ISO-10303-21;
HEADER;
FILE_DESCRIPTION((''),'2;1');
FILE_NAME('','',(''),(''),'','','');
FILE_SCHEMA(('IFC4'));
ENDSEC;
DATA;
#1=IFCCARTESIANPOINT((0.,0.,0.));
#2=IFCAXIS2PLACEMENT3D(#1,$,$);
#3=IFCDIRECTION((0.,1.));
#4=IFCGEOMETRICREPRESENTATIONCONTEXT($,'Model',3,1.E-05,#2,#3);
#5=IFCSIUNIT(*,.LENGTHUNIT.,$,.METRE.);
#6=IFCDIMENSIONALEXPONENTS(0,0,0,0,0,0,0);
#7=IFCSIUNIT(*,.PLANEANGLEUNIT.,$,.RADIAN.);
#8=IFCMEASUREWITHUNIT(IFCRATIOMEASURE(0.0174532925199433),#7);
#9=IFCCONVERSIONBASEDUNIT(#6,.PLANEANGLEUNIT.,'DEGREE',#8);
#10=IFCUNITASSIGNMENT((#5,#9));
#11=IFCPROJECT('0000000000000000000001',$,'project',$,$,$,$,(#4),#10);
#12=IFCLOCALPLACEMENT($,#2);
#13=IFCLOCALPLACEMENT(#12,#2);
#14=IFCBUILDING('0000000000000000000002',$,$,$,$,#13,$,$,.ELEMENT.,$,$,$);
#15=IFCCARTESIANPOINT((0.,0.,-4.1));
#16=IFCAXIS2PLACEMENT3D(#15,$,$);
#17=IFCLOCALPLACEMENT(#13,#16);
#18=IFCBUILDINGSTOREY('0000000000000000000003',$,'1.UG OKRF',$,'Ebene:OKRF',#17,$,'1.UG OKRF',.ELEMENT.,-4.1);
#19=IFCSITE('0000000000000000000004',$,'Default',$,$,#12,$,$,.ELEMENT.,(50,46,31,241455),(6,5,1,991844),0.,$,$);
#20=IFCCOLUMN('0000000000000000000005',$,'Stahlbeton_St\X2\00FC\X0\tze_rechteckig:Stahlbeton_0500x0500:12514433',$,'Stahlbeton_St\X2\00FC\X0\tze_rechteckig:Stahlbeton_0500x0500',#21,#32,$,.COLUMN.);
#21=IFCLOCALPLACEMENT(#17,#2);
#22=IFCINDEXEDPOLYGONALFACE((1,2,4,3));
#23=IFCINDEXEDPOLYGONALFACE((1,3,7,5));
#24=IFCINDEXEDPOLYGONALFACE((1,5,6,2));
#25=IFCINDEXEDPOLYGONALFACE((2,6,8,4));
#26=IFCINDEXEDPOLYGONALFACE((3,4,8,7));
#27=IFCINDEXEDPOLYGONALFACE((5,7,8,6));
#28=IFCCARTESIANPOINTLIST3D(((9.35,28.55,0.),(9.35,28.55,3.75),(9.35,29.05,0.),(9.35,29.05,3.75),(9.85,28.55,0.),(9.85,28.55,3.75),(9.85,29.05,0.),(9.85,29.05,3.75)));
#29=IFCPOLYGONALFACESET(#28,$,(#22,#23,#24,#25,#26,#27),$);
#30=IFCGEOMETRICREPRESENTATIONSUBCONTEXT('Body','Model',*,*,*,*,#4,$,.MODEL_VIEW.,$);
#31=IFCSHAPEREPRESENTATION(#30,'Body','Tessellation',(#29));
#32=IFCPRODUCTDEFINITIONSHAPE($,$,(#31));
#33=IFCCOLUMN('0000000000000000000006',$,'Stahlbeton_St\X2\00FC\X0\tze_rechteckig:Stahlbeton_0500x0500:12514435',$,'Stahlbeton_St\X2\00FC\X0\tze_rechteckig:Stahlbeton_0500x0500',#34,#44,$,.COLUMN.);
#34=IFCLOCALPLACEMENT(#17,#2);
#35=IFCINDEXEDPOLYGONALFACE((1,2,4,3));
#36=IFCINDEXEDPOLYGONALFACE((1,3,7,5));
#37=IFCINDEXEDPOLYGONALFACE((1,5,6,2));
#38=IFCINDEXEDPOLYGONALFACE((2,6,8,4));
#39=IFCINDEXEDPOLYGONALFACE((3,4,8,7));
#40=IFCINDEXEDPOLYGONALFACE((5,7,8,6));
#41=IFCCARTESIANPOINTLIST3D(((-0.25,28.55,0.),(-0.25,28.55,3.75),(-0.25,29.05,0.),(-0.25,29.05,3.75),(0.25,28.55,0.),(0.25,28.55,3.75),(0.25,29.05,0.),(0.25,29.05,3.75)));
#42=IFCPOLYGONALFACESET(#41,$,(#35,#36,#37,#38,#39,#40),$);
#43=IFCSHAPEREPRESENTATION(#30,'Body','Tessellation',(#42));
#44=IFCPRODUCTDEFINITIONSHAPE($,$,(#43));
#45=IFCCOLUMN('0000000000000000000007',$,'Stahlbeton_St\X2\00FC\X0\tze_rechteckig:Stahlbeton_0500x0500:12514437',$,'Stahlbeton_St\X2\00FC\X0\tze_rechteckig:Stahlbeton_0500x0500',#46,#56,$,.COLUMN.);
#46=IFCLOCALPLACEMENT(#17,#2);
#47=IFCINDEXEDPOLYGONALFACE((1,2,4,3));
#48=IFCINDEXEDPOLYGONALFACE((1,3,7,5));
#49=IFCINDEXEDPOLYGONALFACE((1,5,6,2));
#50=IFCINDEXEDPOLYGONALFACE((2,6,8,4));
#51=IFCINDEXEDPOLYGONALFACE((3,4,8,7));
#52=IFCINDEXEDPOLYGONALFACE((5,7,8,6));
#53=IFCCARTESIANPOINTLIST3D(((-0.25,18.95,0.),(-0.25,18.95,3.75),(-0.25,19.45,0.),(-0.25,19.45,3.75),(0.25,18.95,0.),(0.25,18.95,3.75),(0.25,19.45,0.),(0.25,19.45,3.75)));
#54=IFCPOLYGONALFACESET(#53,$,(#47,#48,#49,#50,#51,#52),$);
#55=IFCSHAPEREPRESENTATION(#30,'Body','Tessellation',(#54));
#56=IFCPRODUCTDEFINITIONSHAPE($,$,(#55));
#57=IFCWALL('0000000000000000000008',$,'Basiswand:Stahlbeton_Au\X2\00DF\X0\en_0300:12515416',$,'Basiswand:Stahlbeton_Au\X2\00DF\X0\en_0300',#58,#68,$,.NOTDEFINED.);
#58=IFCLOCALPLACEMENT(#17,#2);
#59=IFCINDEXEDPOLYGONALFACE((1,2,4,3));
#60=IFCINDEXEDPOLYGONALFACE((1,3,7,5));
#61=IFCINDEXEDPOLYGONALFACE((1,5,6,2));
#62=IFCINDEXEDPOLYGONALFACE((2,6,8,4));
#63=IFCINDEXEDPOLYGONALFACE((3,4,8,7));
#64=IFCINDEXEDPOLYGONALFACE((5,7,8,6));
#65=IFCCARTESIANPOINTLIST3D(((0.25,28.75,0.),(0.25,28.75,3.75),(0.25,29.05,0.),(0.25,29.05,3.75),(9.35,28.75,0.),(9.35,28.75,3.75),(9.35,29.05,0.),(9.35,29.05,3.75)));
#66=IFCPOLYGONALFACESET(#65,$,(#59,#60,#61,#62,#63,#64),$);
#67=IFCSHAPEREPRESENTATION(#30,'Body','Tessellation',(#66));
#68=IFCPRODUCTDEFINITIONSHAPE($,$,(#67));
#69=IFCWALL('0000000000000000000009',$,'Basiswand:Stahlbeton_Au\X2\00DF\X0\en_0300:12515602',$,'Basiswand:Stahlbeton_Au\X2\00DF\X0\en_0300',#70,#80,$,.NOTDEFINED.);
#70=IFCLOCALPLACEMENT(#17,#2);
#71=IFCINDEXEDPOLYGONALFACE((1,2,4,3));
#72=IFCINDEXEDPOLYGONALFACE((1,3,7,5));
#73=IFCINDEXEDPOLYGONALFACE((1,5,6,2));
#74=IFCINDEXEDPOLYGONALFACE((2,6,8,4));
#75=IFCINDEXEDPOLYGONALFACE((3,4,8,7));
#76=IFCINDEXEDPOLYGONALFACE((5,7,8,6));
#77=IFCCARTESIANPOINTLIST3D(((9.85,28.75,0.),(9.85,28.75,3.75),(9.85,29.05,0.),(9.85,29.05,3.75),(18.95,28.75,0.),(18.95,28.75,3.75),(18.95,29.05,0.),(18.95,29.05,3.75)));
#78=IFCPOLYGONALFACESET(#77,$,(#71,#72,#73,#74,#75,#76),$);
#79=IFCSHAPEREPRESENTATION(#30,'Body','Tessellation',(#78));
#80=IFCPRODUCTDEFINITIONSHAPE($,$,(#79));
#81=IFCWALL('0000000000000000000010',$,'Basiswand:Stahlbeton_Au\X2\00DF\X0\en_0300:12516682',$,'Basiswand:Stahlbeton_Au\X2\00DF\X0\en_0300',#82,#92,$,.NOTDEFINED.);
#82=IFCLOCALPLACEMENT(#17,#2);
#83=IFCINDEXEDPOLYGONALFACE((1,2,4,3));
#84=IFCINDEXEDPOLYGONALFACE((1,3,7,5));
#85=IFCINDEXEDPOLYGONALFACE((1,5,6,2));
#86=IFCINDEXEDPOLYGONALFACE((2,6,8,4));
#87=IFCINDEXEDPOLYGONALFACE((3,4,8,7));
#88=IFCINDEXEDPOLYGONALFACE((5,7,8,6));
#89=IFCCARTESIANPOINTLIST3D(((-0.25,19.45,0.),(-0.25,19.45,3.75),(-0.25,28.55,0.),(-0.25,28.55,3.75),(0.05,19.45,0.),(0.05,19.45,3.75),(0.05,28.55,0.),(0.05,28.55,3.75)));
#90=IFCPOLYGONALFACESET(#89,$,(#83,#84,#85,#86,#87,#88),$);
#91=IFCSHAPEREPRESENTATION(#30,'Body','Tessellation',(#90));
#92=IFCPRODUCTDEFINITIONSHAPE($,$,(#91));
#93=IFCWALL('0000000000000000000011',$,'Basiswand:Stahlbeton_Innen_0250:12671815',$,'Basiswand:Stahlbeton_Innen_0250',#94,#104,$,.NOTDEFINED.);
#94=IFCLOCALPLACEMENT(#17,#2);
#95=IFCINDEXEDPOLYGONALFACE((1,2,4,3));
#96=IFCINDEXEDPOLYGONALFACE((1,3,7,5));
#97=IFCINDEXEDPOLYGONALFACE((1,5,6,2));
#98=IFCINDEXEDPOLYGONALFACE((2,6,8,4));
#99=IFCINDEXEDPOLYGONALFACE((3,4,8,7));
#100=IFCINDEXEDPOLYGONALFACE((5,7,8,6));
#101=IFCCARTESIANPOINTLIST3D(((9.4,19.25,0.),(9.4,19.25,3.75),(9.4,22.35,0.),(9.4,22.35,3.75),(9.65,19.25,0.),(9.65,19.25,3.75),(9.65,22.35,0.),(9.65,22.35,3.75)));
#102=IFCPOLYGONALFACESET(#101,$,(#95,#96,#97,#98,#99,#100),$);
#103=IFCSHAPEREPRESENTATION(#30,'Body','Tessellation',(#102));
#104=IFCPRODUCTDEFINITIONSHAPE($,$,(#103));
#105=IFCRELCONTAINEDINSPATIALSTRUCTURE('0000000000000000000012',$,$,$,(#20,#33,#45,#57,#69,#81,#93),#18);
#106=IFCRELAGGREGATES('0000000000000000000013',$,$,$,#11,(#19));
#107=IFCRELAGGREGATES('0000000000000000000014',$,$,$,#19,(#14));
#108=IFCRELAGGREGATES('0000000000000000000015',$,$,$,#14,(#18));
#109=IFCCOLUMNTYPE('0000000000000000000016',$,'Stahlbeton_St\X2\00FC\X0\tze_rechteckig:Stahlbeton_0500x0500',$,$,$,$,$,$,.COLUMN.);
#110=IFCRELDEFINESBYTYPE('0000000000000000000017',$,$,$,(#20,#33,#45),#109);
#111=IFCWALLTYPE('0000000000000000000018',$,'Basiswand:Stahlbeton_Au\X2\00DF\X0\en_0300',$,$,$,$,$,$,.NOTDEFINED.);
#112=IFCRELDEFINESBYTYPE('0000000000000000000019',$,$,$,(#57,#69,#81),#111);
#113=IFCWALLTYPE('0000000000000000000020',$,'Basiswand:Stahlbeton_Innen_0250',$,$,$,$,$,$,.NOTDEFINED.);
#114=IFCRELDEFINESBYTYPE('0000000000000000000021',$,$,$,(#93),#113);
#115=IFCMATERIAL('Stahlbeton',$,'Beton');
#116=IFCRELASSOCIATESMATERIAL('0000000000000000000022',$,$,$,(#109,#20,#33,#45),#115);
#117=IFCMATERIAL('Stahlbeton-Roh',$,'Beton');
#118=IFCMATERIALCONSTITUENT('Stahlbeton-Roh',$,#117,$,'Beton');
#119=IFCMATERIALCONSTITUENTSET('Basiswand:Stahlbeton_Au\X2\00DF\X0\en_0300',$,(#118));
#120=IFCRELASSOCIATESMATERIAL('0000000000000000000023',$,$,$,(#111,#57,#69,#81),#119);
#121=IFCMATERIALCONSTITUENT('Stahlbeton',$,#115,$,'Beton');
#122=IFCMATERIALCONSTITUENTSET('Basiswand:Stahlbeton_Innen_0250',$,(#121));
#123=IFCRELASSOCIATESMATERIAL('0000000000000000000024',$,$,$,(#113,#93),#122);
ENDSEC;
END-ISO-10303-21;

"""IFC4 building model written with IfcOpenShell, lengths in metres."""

from ifc_helpers import new_model, entity, si_unit, converted_unit, direction, frame, origin, place, context, subcontext, project, spatial, polyline, indexed_curve, outline, extrude, source, transform, mapped, material, constituent, constituent_set, type_object, type_shapes, element, save


model = new_model("IFC4")

# Units and contexts
model_context = context("Model", 3, precision=1e-05, world=origin(), true_north=direction((0.0, 1.0)))
body_context = subcontext(model_context, "Body", "Model", "MODEL_VIEW")
ifc_project = project(units=[si_unit("LENGTHUNIT", "METRE"), converted_unit("PLANEANGLEUNIT", "DEGREE", entity("IfcRatioMeasure", 0.0174532925199433), si_unit("PLANEANGLEUNIT", "RADIAN"), dimensions=[0, 0, 0, 0, 0, 0, 0])], contexts=[model_context])

# Site, building, storey
site_placement = place(None, origin())
site = spatial("IfcSite", under=ifc_project, at=site_placement, Name="Default", CompositionType="ELEMENT", RefLatitude=(50, 46, 31, 241455), RefLongitude=(6, 5, 1, 991844), RefElevation=0.0)
building_placement = place(site_placement, origin())
building = spatial("IfcBuilding", under=site, at=building_placement, CompositionType="ELEMENT")
storey_placement = place(building_placement, frame((0.0, 0.0, -4.1)))
storey = spatial("IfcBuildingStorey", under=building, at=storey_placement, Name="1.UG OKRF", ObjectType="Ebene:OKRF", LongName="1.UG OKRF", CompositionType="ELEMENT", Elevation=-4.1)

# Columns
ifc_material_1 = material(Name="Stahlbeton", Category="Beton")
column_type = type_object("IfcColumnType", Name="Stahlbeton_Stütze_rechteckig:Stahlbeton_0500x0500", PredefinedType="COLUMN", material=ifc_material_1)
shared_shape = source(origin(), body_context, "Body", "SweptSolid", [
    extrude(outline(indexed_curve([(-0.25, -0.25), (0.25, -0.25), (0.25, 0.25), (-0.25, 0.25), (-0.25, -0.25)], self_intersect=False)), frame((0.0, 0.0, -4.1), z_axis=(0.0, 0.0, 1.0), x_axis=(0.0, -1.0, 0.0)), (0.0, 0.0, 1.0), 3.75),
])
type_shapes(column_type, [shared_shape])
for number, where, name in (
    (1, (9.6, 28.8, 4.1), "Stahlbeton_Stütze_rechteckig:Stahlbeton_0500x0500:12514433"),
    (2, (0.0, 28.8, 4.1), "Stahlbeton_Stütze_rechteckig:Stahlbeton_0500x0500:12514435"),
    (3, (0.0, 19.2, 4.1), "Stahlbeton_Stütze_rechteckig:Stahlbeton_0500x0500:12514437"),
):
    element("IfcColumn", number, at=place(storey_placement, frame(where)), inside=storey, type_object=column_type, material=ifc_material_1, Name=name, ObjectType="Stahlbeton_Stütze_rechteckig:Stahlbeton_0500x0500", PredefinedType="COLUMN", context=body_context, shape_type="MappedRepresentation", body=[
        mapped(shared_shape, transform((0.0, 0.0, 0.0), scale=1.0)),
    ])

# Walls
ifc_material_2 = material(Name="Stahlbeton-Roh", Category="Beton")
ifc_constituent_1 = constituent(ifc_material_2, Name="Stahlbeton-Roh", Category="Beton")
ifc_constituent_set_1 = constituent_set(constituents=[ifc_constituent_1], Name="Basiswand:Stahlbeton_Außen_0300")
wall_type_1 = type_object("IfcWallType", Name="Basiswand:Stahlbeton_Außen_0300", PredefinedType="NOTDEFINED", material=ifc_constituent_set_1)
wall_1_placement = place(storey_placement, frame((0.25, 28.9, 0.0)))
element("IfcWall", 4, at=wall_1_placement, inside=storey, type_object=wall_type_1, material=ifc_constituent_set_1, Name="Basiswand:Stahlbeton_Außen_0300:12515416", ObjectType="Basiswand:Stahlbeton_Außen_0300", PredefinedType="NOTDEFINED", context=body_context, shape_type="SweptSolid", body=[
    extrude(outline(polyline([(-4.55, -0.15), (4.55, -0.15), (4.55, 0.15), (-4.55, 0.15), (-4.55, -0.15)])), frame((4.55, 0.0, 0.0), z_axis=(0.0, 0.0, -1.0), x_axis=(-1.0, 0.0, 0.0)), (0.0, 0.0, -1.0), 3.75),
])
wall_2_placement = place(storey_placement, frame((9.85, 28.9, 0.0)))
element("IfcWall", 5, at=wall_2_placement, inside=storey, type_object=wall_type_1, material=ifc_constituent_set_1, Name="Basiswand:Stahlbeton_Außen_0300:12515602", ObjectType="Basiswand:Stahlbeton_Außen_0300", PredefinedType="NOTDEFINED", context=body_context, shape_type="SweptSolid", body=[
    extrude(outline(polyline([(-4.55, -0.15), (4.55, -0.15), (4.55, 0.15), (-4.55, 0.15), (-4.55, -0.15)])), frame((4.55, 0.0, 0.0), z_axis=(0.0, 0.0, -1.0), x_axis=(1.0, 0.0, 0.0)), (0.0, 0.0, -1.0), 3.75),
])
wall_3_placement = place(storey_placement, frame((-0.1, 19.45, 0.0), z_axis=(0.0, 0.0, 1.0), x_axis=(0.0, 1.0, 0.0)))
element("IfcWall", 6, at=wall_3_placement, inside=storey, type_object=wall_type_1, material=ifc_constituent_set_1, Name="Basiswand:Stahlbeton_Außen_0300:12516682", ObjectType="Basiswand:Stahlbeton_Außen_0300", PredefinedType="NOTDEFINED", context=body_context, shape_type="SweptSolid", body=[
    extrude(outline(polyline([(-0.15, -4.55), (0.15, -4.55), (0.15, 4.55), (-0.15, 4.55), (-0.15, -4.55)])), frame((4.55, 0.0, 0.0), z_axis=(0.0, 0.0, -1.0), x_axis=(0.0, 1.0, 0.0)), (0.0, 0.0, -1.0), 3.75),
])

# Shared definitions
ifc_constituent_2 = constituent(ifc_material_1, Name="Stahlbeton", Category="Beton")
ifc_constituent_set_2 = constituent_set(constituents=[ifc_constituent_2], Name="Basiswand:Stahlbeton_Innen_0250")
wall_type_2 = type_object("IfcWallType", Name="Basiswand:Stahlbeton_Innen_0250", PredefinedType="NOTDEFINED", material=ifc_constituent_set_2)

# Wall
wall_4_placement = place(storey_placement, frame((9.525, 22.35, 0.0), z_axis=(0.0, 0.0, 1.0), x_axis=(0.0, -1.0, 0.0)))
element("IfcWall", 7, at=wall_4_placement, inside=storey, type_object=wall_type_2, material=ifc_constituent_set_2, Name="Basiswand:Stahlbeton_Innen_0250:12671815", ObjectType="Basiswand:Stahlbeton_Innen_0250", PredefinedType="NOTDEFINED", context=body_context, shape_type="SweptSolid", body=[
    extrude(outline(indexed_curve([(-0.125, -1.55), (0.125, -1.55), (0.125, 1.55), (-0.125, 1.55), (-0.125, -1.55)], self_intersect=False)), frame((1.55, 0.0, 0.0), z_axis=(0.0, 0.0, 1.0), x_axis=(0.0, 1.0, 0.0)), (0.0, 0.0, 1.0), 3.75),
])

save(model, "model.ifc")
